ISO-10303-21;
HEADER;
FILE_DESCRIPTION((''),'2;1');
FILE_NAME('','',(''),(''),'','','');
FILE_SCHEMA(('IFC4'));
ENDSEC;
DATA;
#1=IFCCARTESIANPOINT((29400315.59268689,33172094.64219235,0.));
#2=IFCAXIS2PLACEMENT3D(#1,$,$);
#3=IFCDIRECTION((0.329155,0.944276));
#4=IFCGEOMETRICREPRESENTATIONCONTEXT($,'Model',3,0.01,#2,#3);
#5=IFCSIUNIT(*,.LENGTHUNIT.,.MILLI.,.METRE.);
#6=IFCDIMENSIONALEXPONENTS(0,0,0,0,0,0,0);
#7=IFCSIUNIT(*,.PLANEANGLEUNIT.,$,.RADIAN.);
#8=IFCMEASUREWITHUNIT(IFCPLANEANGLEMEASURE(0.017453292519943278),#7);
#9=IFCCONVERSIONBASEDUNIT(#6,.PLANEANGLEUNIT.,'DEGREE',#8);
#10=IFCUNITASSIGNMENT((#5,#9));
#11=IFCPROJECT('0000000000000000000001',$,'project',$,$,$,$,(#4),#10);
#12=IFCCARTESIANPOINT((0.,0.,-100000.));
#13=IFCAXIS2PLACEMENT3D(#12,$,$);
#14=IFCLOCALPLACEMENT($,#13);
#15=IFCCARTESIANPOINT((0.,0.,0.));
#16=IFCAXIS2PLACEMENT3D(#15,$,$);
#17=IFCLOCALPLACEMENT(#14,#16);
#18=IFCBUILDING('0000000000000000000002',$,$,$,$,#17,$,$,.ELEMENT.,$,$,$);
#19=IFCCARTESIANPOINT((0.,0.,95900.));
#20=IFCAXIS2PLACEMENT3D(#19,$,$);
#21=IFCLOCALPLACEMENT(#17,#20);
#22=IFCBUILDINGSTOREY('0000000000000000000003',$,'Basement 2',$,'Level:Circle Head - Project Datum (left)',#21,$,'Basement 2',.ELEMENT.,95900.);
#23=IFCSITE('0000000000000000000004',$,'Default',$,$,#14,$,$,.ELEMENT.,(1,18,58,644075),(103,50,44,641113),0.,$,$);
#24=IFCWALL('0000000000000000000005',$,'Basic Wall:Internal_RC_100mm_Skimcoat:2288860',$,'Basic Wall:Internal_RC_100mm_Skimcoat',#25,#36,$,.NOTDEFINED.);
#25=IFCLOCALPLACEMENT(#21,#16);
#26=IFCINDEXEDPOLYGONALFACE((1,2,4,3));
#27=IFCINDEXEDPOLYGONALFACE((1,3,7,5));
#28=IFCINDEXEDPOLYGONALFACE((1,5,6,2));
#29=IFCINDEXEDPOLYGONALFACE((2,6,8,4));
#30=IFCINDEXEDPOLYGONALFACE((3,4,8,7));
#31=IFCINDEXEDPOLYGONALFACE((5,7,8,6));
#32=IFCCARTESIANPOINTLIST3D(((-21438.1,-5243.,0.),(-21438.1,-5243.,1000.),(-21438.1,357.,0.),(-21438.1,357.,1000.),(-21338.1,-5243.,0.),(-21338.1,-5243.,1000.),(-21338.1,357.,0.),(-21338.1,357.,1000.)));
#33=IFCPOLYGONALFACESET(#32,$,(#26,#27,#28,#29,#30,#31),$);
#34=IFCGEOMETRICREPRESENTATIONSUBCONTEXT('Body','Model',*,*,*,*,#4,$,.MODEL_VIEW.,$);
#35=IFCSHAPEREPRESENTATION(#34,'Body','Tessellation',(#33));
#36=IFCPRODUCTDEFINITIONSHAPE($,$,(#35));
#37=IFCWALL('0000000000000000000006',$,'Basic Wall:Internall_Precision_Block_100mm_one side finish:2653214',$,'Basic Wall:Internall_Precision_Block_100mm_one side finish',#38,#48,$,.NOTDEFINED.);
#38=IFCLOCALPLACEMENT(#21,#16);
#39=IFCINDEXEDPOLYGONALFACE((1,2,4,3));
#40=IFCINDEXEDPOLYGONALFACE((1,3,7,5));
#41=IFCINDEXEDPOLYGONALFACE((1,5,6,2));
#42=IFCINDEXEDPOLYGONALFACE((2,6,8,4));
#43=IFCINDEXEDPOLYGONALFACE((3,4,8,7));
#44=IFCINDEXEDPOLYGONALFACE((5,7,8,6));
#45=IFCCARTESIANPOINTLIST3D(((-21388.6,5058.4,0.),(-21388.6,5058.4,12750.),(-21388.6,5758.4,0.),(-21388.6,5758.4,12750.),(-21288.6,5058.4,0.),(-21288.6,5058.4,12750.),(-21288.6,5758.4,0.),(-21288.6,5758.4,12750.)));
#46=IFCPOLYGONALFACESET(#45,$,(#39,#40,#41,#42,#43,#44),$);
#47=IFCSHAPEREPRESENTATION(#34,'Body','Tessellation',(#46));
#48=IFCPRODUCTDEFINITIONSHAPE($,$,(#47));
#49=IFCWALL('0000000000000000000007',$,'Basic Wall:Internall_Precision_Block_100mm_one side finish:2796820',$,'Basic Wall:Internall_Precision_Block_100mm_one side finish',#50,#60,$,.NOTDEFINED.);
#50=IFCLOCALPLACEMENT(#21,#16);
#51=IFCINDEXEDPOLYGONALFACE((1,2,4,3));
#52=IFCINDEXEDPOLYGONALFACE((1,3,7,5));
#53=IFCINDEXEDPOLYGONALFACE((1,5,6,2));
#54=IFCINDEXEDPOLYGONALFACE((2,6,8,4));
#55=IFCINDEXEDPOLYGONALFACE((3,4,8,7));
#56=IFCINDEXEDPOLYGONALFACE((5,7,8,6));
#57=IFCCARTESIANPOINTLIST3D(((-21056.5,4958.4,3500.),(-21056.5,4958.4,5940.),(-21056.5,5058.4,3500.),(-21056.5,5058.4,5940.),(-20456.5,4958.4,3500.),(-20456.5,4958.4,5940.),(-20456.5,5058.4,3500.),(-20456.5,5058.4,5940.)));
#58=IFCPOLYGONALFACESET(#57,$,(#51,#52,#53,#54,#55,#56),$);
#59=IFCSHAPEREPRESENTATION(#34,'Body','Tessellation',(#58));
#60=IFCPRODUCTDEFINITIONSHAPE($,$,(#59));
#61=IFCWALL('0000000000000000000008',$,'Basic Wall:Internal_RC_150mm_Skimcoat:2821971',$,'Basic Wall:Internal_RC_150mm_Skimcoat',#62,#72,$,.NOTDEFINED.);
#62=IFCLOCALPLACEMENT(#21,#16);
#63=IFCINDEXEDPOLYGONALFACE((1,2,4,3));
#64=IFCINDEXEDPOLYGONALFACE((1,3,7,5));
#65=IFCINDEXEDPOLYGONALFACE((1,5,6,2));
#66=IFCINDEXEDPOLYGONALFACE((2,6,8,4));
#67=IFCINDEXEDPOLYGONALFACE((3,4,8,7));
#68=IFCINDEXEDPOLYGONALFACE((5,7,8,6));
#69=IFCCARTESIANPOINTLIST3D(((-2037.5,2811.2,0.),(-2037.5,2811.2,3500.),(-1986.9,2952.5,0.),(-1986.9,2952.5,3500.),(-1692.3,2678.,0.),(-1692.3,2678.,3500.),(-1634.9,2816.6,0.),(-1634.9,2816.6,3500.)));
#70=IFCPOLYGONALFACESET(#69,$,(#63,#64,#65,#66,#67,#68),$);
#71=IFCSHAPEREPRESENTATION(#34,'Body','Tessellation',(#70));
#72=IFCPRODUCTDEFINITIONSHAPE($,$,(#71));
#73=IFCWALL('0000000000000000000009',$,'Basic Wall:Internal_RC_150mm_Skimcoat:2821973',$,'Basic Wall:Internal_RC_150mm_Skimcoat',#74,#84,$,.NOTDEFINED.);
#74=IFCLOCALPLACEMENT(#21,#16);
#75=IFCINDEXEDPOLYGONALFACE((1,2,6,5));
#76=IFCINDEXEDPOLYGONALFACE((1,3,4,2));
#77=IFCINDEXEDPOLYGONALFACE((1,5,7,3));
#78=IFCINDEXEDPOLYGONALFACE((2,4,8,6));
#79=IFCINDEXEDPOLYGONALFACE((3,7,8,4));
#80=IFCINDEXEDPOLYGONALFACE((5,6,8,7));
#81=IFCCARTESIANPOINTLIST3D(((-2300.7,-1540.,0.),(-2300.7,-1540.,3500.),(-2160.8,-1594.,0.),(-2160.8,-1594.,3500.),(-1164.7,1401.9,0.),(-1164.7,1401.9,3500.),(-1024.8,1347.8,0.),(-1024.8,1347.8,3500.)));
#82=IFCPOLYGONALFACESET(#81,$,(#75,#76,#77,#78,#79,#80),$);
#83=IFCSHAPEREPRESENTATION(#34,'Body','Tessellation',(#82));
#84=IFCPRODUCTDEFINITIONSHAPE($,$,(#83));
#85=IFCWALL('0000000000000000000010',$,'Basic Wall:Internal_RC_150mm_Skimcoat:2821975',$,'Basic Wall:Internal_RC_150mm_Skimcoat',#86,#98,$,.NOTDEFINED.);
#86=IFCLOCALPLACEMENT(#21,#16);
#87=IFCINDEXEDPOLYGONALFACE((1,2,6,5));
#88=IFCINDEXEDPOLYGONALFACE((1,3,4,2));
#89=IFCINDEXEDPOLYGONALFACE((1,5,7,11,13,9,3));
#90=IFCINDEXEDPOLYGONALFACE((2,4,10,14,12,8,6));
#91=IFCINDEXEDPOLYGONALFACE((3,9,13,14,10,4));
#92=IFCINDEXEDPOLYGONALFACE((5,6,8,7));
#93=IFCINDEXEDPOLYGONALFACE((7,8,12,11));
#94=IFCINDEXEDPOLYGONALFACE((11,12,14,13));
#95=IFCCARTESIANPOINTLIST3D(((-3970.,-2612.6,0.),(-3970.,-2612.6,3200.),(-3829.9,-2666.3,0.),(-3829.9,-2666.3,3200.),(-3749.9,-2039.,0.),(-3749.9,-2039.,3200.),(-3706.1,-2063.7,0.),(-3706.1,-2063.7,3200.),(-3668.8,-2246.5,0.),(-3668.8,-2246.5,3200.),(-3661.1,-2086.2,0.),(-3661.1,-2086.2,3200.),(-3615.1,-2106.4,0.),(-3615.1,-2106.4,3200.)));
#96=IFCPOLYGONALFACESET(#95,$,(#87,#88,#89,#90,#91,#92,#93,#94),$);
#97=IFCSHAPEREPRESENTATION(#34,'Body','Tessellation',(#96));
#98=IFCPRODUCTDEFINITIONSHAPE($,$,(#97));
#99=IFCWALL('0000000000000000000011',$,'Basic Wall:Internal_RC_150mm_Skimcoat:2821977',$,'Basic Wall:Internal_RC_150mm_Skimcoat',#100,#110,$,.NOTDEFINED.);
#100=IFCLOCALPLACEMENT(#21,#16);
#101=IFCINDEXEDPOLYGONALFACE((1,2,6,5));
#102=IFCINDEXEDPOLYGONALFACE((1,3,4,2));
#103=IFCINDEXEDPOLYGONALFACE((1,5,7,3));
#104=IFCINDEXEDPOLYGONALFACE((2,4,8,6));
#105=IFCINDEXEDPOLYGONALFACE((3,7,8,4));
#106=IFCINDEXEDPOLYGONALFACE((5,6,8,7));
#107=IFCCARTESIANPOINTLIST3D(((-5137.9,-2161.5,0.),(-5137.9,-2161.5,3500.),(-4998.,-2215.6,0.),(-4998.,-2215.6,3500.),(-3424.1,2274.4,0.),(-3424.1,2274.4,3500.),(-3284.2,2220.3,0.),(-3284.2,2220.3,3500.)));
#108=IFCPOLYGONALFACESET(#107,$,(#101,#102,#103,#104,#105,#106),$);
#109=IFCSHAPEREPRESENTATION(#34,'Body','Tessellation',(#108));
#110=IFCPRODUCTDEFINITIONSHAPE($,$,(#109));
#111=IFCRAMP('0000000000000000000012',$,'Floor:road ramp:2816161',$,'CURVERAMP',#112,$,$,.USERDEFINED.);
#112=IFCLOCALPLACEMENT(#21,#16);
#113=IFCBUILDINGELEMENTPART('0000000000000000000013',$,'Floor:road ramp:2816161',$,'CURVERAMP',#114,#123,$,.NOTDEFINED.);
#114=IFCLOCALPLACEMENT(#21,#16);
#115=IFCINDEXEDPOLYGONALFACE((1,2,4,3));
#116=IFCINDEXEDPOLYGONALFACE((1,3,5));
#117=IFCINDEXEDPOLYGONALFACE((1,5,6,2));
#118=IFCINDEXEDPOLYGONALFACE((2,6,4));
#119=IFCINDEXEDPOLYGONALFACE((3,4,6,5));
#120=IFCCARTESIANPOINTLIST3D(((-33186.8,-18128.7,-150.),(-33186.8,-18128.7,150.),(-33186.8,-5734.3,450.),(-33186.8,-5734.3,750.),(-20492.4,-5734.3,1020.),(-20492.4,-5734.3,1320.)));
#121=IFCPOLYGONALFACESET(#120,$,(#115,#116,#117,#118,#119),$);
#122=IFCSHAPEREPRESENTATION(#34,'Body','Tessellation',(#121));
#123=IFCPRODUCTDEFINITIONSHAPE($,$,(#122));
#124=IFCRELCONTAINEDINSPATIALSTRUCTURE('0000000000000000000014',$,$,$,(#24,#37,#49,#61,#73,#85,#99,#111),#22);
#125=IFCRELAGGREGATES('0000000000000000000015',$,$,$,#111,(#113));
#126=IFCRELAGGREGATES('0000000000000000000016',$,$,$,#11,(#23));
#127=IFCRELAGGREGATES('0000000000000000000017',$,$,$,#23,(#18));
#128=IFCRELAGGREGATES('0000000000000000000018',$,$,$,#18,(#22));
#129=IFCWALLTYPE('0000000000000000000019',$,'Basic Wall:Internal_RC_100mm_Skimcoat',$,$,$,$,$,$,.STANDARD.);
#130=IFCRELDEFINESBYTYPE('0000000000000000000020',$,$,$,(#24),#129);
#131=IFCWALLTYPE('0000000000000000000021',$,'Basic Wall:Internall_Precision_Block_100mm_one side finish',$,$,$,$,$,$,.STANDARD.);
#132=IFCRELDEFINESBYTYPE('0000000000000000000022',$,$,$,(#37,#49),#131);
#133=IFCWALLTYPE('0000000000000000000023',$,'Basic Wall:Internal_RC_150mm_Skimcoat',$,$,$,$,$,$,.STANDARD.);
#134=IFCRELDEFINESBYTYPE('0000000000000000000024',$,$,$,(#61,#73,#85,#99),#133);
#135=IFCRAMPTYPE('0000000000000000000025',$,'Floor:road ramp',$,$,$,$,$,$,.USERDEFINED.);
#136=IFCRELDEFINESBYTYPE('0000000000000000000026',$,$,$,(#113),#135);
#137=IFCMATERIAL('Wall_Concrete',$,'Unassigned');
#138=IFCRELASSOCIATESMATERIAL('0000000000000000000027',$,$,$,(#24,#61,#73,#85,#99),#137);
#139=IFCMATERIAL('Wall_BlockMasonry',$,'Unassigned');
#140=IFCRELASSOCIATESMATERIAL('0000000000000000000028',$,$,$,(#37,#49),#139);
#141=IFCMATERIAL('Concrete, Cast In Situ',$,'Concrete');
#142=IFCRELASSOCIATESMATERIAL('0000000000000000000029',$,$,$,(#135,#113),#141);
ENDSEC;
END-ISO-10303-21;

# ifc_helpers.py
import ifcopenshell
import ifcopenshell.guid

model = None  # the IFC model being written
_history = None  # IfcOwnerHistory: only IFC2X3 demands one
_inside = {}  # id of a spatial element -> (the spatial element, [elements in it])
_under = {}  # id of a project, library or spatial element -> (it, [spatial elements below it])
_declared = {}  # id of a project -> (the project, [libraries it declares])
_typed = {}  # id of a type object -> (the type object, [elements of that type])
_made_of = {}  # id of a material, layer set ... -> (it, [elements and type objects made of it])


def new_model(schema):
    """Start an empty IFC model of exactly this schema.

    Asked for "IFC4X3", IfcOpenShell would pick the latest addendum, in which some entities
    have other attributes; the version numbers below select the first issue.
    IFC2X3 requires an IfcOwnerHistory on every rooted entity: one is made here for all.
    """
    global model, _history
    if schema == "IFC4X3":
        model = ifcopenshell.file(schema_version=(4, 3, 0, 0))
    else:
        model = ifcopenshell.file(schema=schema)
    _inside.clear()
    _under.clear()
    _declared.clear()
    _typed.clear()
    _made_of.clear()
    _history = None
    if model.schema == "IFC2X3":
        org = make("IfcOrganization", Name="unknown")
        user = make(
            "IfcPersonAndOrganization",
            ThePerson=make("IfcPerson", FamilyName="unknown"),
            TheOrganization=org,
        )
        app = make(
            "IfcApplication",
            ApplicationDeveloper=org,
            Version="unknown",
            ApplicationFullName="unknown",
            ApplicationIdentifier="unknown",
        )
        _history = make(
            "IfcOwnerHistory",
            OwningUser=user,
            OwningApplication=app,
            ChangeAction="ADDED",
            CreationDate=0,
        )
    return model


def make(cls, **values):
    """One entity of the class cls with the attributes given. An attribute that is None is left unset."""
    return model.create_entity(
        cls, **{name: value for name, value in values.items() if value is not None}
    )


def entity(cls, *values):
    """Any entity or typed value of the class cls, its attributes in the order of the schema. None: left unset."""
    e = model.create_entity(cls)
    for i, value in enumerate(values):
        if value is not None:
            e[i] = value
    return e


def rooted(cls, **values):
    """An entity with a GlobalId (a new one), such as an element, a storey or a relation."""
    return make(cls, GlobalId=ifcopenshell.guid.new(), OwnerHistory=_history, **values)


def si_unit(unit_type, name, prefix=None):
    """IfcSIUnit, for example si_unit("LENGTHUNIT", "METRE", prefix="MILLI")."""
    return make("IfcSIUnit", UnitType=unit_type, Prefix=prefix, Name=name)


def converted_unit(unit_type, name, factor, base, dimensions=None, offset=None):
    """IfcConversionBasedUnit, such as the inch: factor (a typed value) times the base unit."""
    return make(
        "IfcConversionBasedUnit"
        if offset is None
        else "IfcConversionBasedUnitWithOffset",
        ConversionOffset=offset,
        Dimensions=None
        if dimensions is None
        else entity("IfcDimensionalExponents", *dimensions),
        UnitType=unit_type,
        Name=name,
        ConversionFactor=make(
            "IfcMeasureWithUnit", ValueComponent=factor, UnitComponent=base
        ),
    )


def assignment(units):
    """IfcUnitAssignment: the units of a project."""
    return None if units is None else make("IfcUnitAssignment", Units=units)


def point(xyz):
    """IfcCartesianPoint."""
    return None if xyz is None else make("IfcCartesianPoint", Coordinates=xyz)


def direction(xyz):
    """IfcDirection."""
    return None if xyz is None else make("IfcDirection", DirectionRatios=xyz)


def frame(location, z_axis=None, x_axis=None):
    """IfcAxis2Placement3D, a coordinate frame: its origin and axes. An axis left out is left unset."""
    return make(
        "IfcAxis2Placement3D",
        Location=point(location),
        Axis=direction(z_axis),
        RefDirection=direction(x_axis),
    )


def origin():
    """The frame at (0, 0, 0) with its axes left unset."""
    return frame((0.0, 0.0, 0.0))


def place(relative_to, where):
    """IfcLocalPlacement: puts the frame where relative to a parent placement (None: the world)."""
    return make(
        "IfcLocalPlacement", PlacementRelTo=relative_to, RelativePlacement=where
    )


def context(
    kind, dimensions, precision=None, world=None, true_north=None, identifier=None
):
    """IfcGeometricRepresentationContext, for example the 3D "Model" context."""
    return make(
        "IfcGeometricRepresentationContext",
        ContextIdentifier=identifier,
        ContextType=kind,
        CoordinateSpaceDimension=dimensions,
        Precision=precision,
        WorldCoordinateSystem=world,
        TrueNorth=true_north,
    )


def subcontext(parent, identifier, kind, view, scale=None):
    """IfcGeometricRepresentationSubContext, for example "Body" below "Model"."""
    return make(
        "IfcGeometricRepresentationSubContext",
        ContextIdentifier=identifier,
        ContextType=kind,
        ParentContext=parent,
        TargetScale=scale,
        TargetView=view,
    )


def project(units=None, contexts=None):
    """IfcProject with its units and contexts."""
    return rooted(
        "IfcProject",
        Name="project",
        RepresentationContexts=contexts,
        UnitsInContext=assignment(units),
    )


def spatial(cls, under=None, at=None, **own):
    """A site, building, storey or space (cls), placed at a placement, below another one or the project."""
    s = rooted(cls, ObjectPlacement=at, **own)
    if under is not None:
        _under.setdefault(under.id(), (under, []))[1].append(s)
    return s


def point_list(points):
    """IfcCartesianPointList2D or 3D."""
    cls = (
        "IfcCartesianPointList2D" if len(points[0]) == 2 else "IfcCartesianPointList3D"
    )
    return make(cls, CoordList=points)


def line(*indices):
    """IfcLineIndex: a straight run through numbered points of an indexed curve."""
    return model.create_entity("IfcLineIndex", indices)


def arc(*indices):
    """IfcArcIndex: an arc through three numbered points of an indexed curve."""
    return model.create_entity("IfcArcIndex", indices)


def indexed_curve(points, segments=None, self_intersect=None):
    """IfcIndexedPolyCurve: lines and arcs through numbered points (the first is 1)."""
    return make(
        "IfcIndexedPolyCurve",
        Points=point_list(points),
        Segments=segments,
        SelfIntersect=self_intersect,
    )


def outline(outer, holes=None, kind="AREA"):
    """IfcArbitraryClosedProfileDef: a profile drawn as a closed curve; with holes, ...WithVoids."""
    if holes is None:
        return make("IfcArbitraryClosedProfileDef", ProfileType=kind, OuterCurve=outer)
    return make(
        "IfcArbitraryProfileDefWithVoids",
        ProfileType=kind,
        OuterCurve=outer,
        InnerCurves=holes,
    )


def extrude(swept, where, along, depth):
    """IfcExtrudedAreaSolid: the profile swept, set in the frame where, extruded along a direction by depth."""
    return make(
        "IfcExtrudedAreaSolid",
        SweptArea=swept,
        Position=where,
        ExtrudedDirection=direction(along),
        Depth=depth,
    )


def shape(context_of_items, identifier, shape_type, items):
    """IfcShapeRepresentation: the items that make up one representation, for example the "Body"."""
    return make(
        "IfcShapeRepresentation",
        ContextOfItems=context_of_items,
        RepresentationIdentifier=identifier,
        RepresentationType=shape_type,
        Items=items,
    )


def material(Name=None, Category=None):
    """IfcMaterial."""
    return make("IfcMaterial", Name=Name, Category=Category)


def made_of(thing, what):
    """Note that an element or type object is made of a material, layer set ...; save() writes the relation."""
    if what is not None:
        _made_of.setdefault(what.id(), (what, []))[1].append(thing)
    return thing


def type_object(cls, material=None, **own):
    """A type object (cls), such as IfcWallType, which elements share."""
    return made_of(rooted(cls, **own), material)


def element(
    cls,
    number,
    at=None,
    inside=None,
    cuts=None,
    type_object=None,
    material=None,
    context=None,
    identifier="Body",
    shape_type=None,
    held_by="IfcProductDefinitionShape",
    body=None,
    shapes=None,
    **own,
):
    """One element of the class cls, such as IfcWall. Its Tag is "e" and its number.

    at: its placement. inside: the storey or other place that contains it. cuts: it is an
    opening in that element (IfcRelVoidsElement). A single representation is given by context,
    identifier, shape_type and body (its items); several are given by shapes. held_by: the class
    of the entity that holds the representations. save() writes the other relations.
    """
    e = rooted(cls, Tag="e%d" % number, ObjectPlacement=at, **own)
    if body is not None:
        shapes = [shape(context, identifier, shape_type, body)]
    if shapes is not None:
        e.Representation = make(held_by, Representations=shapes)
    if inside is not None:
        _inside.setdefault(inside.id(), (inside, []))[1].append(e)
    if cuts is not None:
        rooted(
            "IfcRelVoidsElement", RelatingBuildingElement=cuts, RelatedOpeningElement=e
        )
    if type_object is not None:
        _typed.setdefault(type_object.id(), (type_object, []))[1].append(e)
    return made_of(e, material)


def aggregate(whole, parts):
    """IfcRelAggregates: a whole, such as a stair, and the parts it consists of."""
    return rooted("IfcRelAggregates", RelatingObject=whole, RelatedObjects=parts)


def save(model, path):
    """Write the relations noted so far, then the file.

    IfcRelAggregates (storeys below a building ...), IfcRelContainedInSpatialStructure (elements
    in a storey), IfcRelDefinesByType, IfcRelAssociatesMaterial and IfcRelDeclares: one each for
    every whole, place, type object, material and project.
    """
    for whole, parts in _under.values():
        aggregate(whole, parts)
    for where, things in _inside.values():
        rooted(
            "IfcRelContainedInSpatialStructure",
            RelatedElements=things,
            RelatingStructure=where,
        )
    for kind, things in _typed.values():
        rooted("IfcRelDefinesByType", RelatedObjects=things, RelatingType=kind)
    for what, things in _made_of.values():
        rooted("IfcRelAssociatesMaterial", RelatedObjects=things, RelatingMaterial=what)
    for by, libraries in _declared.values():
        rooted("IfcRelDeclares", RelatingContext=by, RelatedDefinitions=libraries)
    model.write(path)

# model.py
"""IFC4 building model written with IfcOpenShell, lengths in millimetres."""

from ifc_helpers import new_model, entity, si_unit, converted_unit, direction, frame, origin, place, context, subcontext, project, spatial, line, arc, indexed_curve, outline, extrude, material, type_object, element, aggregate, save


model = new_model("IFC4")

# Units and contexts
model_context = context("Model", 3, precision=0.01, world=frame((29400315.59268689, 33172094.64219235, 0.0)), true_north=direction((0.329155, 0.944276)))
body_context = subcontext(model_context, "Body", "Model", "MODEL_VIEW")
ifc_project = project(units=[si_unit("LENGTHUNIT", "METRE", prefix="MILLI"), converted_unit("PLANEANGLEUNIT", "DEGREE", entity("IfcPlaneAngleMeasure", 0.017453292519943278), si_unit("PLANEANGLEUNIT", "RADIAN"), dimensions=[0, 0, 0, 0, 0, 0, 0])], contexts=[model_context])

# Site, building, storey
site_placement = place(None, frame((0.0, 0.0, -100000.0)))
site = spatial("IfcSite", under=ifc_project, at=site_placement, Name="Default", CompositionType="ELEMENT", RefLatitude=(1, 18, 58, 644075), RefLongitude=(103, 50, 44, 641113), RefElevation=0.0)
building_placement = place(site_placement, origin())
building = spatial("IfcBuilding", under=site, at=building_placement, CompositionType="ELEMENT")
storey_placement = place(building_placement, frame((0.0, 0.0, 95900.0)))
storey = spatial("IfcBuildingStorey", under=building, at=storey_placement, Name="Basement 2", ObjectType="Level:Circle Head - Project Datum (left)", LongName="Basement 2", CompositionType="ELEMENT", Elevation=95900.0)

# Shared definitions
ifc_material_1 = material(Name="Concrete, Cast In Situ", Category="Concrete")

# Walls
ifc_material_2 = material(Name="Wall_Concrete", Category="Unassigned")
wall_type_1 = type_object("IfcWallType", Name="Basic Wall:Internal_RC_100mm_Skimcoat", PredefinedType="STANDARD")
wall_1_placement = place(storey_placement, frame((-21388.1, 357.0, 0.0), z_axis=(0.0, 0.0, 1.0), x_axis=(0.0, -1.0, 0.0)))
element("IfcWall", 1, at=wall_1_placement, inside=storey, type_object=wall_type_1, material=ifc_material_2, Name="Basic Wall:Internal_RC_100mm_Skimcoat:2288860", ObjectType="Basic Wall:Internal_RC_100mm_Skimcoat", PredefinedType="NOTDEFINED", context=body_context, shape_type="SweptSolid", body=[
    extrude(outline(indexed_curve([(5600.0, 50.0), (0.0, 50.0), (0.0, -50.0), (5600.0, -50.0), (5600.0, 50.0)], self_intersect=False)), origin(), (0.0, 0.0, 1.0), 1000.0),
])
ifc_material_3 = material(Name="Wall_BlockMasonry", Category="Unassigned")
wall_type_2 = type_object("IfcWallType", Name="Basic Wall:Internall_Precision_Block_100mm_one side finish", PredefinedType="STANDARD")
wall_2_placement = place(storey_placement, frame((-21338.6, 5058.4, 0.0), z_axis=(0.0, 0.0, 1.0), x_axis=(0.0, 1.0, 0.0)))
element("IfcWall", 2, at=wall_2_placement, inside=storey, type_object=wall_type_2, material=ifc_material_3, Name="Basic Wall:Internall_Precision_Block_100mm_one side finish:2653214", ObjectType="Basic Wall:Internall_Precision_Block_100mm_one side finish", PredefinedType="NOTDEFINED", context=body_context, shape_type="SweptSolid", body=[
    extrude(outline(indexed_curve([(700.0, 50.0), (0.0, 50.0), (0.0, -50.0), (700.0, -50.0), (700.0, 50.0)], self_intersect=False)), origin(), (0.0, 0.0, 1.0), 12750.0),
])
wall_3_placement = place(storey_placement, frame((-20456.5, 5008.4, 3500.0), z_axis=(0.0, 0.0, 1.0), x_axis=(-1.0, 0.0, 0.0)))
element("IfcWall", 3, at=wall_3_placement, inside=storey, type_object=wall_type_2, material=ifc_material_3, Name="Basic Wall:Internall_Precision_Block_100mm_one side finish:2796820", ObjectType="Basic Wall:Internall_Precision_Block_100mm_one side finish", PredefinedType="NOTDEFINED", context=body_context, shape_type="SweptSolid", body=[
    extrude(outline(indexed_curve([(-300.0, -50.0), (300.0, -50.0), (300.0, 50.0), (-300.0, 50.0), (-300.0, -50.0)], self_intersect=False)), frame((300.0, 0.0, 0.0)), (0.0, 0.0, 1.0), 2440.0),
])
wall_type_3 = type_object("IfcWallType", Name="Basic Wall:Internal_RC_150mm_Skimcoat", PredefinedType="STANDARD")
wall_4_placement = place(storey_placement, frame((-2013.9, 2882.5, 0.0), z_axis=(0.0, 0.0, 1.0), x_axis=(0.932914, -0.3601, 0.0)))
element("IfcWall", 4, at=wall_4_placement, inside=storey, type_object=wall_type_3, material=ifc_material_2, Name="Basic Wall:Internal_RC_150mm_Skimcoat:2821971", ObjectType="Basic Wall:Internal_RC_150mm_Skimcoat", PredefinedType="NOTDEFINED", context=body_context, shape_type="SweptSolid", body=[
    extrude(outline(indexed_curve([(373.7, -75.0), (377.3, 75.0), (0.0, 75.0), (3.7, -75.0), (373.7, -75.0)], self_intersect=False)), origin(), (0.0, 0.0, 1.0), 3500.0),
])
wall_5_placement = place(storey_placement, frame((-1094.8, 1374.8, 0.0), z_axis=(0.0, 0.0, 1.0), x_axis=(-0.360234, -0.932862, 0.0)))
element("IfcWall", 5, at=wall_5_placement, inside=storey, type_object=wall_type_3, material=ifc_material_2, Name="Basic Wall:Internal_RC_150mm_Skimcoat:2821973", ObjectType="Basic Wall:Internal_RC_150mm_Skimcoat", PredefinedType="NOTDEFINED", context=body_context, shape_type="SweptSolid", body=[
    extrude(outline(indexed_curve([(3153.5, 75.0), (0.0, 75.0), (0.0, -75.0), (3153.5, -75.0), (3153.5, 75.0)], self_intersect=False)), origin(), (0.0, 0.0, 1.0), 3500.0),
])
wall_6_placement = place(storey_placement, frame((-3679.8, -2065.9, 0.0), z_axis=(0.0, 0.0, 1.0), x_axis=(-0.35828, -0.933614, 0.0)))
element("IfcWall", 6, at=wall_6_placement, inside=storey, type_object=wall_type_3, material=ifc_material_2, Name="Basic Wall:Internal_RC_150mm_Skimcoat:2821975", ObjectType="Basic Wall:Internal_RC_150mm_Skimcoat", PredefinedType="NOTDEFINED", context=body_context, shape_type="SweptSolid", body=[
    extrude(outline(indexed_curve([(614.3, -75.0), (614.3, 75.0), (164.7, 75.0), (14.6, 75.0), (10.1, -0.3), (0.0, -75.0)], segments=[line(1, 2, 3, 4), arc(4, 5, 6), line(6, 1)], self_intersect=False)), origin(), (0.0, 0.0, 1.0), 3200.0),
])
wall_7_placement = place(storey_placement, frame((-5067.9, -2188.6, 0.0), z_axis=(0.0, 0.0, 1.0), x_axis=(0.360381, 0.932805, 0.0)))
element("IfcWall", 7, at=wall_7_placement, inside=storey, type_object=wall_type_3, material=ifc_material_2, Name="Basic Wall:Internal_RC_150mm_Skimcoat:2821977", ObjectType="Basic Wall:Internal_RC_150mm_Skimcoat", PredefinedType="NOTDEFINED", context=body_context, shape_type="SweptSolid", body=[
    extrude(outline(indexed_curve([(4755.5, 75.0), (0.0, 75.0), (0.0, -75.0), (4755.5, -75.0), (4755.5, 75.0)], self_intersect=False)), origin(), (0.0, 0.0, 1.0), 3500.0),
])

# Ramp, building element part
ramp_1_placement = place(storey_placement, frame((-33186.8, -21275.8, -150.0)))
ramp_1 = element("IfcRamp", 8, at=ramp_1_placement, inside=storey, Name="Floor:road ramp:2816161", ObjectType="CURVERAMP", PredefinedType="USERDEFINED")
ramp_type = type_object("IfcRampType", Name="Floor:road ramp", PredefinedType="USERDEFINED", material=ifc_material_1)
building_element_part_1_placement = place(ramp_1_placement, origin())
building_element_part_1 = element("IfcBuildingElementPart", 9, at=building_element_part_1_placement, type_object=ramp_type, material=ifc_material_1, Name="Floor:road ramp:2816161", ObjectType="CURVERAMP", PredefinedType="NOTDEFINED", context=body_context, shape_type="SweptSolid", body=[
    extrude(outline(indexed_curve([(-6353.6, 6190.7), (-6353.6, -6218.2), (6353.6, 6218.2), (-6353.6, 6190.7)], self_intersect=False)), frame((6347.2, 9344.4, 885.0), z_axis=(-0.044804, -0.048304, 0.997827), x_axis=(0.998996, -0.002166, 0.044752)), (-0.044752, -0.048352, -0.997827), 300.0),
])
aggregate(ramp_1, [building_element_part_1])

save(model, "model.ifc")
